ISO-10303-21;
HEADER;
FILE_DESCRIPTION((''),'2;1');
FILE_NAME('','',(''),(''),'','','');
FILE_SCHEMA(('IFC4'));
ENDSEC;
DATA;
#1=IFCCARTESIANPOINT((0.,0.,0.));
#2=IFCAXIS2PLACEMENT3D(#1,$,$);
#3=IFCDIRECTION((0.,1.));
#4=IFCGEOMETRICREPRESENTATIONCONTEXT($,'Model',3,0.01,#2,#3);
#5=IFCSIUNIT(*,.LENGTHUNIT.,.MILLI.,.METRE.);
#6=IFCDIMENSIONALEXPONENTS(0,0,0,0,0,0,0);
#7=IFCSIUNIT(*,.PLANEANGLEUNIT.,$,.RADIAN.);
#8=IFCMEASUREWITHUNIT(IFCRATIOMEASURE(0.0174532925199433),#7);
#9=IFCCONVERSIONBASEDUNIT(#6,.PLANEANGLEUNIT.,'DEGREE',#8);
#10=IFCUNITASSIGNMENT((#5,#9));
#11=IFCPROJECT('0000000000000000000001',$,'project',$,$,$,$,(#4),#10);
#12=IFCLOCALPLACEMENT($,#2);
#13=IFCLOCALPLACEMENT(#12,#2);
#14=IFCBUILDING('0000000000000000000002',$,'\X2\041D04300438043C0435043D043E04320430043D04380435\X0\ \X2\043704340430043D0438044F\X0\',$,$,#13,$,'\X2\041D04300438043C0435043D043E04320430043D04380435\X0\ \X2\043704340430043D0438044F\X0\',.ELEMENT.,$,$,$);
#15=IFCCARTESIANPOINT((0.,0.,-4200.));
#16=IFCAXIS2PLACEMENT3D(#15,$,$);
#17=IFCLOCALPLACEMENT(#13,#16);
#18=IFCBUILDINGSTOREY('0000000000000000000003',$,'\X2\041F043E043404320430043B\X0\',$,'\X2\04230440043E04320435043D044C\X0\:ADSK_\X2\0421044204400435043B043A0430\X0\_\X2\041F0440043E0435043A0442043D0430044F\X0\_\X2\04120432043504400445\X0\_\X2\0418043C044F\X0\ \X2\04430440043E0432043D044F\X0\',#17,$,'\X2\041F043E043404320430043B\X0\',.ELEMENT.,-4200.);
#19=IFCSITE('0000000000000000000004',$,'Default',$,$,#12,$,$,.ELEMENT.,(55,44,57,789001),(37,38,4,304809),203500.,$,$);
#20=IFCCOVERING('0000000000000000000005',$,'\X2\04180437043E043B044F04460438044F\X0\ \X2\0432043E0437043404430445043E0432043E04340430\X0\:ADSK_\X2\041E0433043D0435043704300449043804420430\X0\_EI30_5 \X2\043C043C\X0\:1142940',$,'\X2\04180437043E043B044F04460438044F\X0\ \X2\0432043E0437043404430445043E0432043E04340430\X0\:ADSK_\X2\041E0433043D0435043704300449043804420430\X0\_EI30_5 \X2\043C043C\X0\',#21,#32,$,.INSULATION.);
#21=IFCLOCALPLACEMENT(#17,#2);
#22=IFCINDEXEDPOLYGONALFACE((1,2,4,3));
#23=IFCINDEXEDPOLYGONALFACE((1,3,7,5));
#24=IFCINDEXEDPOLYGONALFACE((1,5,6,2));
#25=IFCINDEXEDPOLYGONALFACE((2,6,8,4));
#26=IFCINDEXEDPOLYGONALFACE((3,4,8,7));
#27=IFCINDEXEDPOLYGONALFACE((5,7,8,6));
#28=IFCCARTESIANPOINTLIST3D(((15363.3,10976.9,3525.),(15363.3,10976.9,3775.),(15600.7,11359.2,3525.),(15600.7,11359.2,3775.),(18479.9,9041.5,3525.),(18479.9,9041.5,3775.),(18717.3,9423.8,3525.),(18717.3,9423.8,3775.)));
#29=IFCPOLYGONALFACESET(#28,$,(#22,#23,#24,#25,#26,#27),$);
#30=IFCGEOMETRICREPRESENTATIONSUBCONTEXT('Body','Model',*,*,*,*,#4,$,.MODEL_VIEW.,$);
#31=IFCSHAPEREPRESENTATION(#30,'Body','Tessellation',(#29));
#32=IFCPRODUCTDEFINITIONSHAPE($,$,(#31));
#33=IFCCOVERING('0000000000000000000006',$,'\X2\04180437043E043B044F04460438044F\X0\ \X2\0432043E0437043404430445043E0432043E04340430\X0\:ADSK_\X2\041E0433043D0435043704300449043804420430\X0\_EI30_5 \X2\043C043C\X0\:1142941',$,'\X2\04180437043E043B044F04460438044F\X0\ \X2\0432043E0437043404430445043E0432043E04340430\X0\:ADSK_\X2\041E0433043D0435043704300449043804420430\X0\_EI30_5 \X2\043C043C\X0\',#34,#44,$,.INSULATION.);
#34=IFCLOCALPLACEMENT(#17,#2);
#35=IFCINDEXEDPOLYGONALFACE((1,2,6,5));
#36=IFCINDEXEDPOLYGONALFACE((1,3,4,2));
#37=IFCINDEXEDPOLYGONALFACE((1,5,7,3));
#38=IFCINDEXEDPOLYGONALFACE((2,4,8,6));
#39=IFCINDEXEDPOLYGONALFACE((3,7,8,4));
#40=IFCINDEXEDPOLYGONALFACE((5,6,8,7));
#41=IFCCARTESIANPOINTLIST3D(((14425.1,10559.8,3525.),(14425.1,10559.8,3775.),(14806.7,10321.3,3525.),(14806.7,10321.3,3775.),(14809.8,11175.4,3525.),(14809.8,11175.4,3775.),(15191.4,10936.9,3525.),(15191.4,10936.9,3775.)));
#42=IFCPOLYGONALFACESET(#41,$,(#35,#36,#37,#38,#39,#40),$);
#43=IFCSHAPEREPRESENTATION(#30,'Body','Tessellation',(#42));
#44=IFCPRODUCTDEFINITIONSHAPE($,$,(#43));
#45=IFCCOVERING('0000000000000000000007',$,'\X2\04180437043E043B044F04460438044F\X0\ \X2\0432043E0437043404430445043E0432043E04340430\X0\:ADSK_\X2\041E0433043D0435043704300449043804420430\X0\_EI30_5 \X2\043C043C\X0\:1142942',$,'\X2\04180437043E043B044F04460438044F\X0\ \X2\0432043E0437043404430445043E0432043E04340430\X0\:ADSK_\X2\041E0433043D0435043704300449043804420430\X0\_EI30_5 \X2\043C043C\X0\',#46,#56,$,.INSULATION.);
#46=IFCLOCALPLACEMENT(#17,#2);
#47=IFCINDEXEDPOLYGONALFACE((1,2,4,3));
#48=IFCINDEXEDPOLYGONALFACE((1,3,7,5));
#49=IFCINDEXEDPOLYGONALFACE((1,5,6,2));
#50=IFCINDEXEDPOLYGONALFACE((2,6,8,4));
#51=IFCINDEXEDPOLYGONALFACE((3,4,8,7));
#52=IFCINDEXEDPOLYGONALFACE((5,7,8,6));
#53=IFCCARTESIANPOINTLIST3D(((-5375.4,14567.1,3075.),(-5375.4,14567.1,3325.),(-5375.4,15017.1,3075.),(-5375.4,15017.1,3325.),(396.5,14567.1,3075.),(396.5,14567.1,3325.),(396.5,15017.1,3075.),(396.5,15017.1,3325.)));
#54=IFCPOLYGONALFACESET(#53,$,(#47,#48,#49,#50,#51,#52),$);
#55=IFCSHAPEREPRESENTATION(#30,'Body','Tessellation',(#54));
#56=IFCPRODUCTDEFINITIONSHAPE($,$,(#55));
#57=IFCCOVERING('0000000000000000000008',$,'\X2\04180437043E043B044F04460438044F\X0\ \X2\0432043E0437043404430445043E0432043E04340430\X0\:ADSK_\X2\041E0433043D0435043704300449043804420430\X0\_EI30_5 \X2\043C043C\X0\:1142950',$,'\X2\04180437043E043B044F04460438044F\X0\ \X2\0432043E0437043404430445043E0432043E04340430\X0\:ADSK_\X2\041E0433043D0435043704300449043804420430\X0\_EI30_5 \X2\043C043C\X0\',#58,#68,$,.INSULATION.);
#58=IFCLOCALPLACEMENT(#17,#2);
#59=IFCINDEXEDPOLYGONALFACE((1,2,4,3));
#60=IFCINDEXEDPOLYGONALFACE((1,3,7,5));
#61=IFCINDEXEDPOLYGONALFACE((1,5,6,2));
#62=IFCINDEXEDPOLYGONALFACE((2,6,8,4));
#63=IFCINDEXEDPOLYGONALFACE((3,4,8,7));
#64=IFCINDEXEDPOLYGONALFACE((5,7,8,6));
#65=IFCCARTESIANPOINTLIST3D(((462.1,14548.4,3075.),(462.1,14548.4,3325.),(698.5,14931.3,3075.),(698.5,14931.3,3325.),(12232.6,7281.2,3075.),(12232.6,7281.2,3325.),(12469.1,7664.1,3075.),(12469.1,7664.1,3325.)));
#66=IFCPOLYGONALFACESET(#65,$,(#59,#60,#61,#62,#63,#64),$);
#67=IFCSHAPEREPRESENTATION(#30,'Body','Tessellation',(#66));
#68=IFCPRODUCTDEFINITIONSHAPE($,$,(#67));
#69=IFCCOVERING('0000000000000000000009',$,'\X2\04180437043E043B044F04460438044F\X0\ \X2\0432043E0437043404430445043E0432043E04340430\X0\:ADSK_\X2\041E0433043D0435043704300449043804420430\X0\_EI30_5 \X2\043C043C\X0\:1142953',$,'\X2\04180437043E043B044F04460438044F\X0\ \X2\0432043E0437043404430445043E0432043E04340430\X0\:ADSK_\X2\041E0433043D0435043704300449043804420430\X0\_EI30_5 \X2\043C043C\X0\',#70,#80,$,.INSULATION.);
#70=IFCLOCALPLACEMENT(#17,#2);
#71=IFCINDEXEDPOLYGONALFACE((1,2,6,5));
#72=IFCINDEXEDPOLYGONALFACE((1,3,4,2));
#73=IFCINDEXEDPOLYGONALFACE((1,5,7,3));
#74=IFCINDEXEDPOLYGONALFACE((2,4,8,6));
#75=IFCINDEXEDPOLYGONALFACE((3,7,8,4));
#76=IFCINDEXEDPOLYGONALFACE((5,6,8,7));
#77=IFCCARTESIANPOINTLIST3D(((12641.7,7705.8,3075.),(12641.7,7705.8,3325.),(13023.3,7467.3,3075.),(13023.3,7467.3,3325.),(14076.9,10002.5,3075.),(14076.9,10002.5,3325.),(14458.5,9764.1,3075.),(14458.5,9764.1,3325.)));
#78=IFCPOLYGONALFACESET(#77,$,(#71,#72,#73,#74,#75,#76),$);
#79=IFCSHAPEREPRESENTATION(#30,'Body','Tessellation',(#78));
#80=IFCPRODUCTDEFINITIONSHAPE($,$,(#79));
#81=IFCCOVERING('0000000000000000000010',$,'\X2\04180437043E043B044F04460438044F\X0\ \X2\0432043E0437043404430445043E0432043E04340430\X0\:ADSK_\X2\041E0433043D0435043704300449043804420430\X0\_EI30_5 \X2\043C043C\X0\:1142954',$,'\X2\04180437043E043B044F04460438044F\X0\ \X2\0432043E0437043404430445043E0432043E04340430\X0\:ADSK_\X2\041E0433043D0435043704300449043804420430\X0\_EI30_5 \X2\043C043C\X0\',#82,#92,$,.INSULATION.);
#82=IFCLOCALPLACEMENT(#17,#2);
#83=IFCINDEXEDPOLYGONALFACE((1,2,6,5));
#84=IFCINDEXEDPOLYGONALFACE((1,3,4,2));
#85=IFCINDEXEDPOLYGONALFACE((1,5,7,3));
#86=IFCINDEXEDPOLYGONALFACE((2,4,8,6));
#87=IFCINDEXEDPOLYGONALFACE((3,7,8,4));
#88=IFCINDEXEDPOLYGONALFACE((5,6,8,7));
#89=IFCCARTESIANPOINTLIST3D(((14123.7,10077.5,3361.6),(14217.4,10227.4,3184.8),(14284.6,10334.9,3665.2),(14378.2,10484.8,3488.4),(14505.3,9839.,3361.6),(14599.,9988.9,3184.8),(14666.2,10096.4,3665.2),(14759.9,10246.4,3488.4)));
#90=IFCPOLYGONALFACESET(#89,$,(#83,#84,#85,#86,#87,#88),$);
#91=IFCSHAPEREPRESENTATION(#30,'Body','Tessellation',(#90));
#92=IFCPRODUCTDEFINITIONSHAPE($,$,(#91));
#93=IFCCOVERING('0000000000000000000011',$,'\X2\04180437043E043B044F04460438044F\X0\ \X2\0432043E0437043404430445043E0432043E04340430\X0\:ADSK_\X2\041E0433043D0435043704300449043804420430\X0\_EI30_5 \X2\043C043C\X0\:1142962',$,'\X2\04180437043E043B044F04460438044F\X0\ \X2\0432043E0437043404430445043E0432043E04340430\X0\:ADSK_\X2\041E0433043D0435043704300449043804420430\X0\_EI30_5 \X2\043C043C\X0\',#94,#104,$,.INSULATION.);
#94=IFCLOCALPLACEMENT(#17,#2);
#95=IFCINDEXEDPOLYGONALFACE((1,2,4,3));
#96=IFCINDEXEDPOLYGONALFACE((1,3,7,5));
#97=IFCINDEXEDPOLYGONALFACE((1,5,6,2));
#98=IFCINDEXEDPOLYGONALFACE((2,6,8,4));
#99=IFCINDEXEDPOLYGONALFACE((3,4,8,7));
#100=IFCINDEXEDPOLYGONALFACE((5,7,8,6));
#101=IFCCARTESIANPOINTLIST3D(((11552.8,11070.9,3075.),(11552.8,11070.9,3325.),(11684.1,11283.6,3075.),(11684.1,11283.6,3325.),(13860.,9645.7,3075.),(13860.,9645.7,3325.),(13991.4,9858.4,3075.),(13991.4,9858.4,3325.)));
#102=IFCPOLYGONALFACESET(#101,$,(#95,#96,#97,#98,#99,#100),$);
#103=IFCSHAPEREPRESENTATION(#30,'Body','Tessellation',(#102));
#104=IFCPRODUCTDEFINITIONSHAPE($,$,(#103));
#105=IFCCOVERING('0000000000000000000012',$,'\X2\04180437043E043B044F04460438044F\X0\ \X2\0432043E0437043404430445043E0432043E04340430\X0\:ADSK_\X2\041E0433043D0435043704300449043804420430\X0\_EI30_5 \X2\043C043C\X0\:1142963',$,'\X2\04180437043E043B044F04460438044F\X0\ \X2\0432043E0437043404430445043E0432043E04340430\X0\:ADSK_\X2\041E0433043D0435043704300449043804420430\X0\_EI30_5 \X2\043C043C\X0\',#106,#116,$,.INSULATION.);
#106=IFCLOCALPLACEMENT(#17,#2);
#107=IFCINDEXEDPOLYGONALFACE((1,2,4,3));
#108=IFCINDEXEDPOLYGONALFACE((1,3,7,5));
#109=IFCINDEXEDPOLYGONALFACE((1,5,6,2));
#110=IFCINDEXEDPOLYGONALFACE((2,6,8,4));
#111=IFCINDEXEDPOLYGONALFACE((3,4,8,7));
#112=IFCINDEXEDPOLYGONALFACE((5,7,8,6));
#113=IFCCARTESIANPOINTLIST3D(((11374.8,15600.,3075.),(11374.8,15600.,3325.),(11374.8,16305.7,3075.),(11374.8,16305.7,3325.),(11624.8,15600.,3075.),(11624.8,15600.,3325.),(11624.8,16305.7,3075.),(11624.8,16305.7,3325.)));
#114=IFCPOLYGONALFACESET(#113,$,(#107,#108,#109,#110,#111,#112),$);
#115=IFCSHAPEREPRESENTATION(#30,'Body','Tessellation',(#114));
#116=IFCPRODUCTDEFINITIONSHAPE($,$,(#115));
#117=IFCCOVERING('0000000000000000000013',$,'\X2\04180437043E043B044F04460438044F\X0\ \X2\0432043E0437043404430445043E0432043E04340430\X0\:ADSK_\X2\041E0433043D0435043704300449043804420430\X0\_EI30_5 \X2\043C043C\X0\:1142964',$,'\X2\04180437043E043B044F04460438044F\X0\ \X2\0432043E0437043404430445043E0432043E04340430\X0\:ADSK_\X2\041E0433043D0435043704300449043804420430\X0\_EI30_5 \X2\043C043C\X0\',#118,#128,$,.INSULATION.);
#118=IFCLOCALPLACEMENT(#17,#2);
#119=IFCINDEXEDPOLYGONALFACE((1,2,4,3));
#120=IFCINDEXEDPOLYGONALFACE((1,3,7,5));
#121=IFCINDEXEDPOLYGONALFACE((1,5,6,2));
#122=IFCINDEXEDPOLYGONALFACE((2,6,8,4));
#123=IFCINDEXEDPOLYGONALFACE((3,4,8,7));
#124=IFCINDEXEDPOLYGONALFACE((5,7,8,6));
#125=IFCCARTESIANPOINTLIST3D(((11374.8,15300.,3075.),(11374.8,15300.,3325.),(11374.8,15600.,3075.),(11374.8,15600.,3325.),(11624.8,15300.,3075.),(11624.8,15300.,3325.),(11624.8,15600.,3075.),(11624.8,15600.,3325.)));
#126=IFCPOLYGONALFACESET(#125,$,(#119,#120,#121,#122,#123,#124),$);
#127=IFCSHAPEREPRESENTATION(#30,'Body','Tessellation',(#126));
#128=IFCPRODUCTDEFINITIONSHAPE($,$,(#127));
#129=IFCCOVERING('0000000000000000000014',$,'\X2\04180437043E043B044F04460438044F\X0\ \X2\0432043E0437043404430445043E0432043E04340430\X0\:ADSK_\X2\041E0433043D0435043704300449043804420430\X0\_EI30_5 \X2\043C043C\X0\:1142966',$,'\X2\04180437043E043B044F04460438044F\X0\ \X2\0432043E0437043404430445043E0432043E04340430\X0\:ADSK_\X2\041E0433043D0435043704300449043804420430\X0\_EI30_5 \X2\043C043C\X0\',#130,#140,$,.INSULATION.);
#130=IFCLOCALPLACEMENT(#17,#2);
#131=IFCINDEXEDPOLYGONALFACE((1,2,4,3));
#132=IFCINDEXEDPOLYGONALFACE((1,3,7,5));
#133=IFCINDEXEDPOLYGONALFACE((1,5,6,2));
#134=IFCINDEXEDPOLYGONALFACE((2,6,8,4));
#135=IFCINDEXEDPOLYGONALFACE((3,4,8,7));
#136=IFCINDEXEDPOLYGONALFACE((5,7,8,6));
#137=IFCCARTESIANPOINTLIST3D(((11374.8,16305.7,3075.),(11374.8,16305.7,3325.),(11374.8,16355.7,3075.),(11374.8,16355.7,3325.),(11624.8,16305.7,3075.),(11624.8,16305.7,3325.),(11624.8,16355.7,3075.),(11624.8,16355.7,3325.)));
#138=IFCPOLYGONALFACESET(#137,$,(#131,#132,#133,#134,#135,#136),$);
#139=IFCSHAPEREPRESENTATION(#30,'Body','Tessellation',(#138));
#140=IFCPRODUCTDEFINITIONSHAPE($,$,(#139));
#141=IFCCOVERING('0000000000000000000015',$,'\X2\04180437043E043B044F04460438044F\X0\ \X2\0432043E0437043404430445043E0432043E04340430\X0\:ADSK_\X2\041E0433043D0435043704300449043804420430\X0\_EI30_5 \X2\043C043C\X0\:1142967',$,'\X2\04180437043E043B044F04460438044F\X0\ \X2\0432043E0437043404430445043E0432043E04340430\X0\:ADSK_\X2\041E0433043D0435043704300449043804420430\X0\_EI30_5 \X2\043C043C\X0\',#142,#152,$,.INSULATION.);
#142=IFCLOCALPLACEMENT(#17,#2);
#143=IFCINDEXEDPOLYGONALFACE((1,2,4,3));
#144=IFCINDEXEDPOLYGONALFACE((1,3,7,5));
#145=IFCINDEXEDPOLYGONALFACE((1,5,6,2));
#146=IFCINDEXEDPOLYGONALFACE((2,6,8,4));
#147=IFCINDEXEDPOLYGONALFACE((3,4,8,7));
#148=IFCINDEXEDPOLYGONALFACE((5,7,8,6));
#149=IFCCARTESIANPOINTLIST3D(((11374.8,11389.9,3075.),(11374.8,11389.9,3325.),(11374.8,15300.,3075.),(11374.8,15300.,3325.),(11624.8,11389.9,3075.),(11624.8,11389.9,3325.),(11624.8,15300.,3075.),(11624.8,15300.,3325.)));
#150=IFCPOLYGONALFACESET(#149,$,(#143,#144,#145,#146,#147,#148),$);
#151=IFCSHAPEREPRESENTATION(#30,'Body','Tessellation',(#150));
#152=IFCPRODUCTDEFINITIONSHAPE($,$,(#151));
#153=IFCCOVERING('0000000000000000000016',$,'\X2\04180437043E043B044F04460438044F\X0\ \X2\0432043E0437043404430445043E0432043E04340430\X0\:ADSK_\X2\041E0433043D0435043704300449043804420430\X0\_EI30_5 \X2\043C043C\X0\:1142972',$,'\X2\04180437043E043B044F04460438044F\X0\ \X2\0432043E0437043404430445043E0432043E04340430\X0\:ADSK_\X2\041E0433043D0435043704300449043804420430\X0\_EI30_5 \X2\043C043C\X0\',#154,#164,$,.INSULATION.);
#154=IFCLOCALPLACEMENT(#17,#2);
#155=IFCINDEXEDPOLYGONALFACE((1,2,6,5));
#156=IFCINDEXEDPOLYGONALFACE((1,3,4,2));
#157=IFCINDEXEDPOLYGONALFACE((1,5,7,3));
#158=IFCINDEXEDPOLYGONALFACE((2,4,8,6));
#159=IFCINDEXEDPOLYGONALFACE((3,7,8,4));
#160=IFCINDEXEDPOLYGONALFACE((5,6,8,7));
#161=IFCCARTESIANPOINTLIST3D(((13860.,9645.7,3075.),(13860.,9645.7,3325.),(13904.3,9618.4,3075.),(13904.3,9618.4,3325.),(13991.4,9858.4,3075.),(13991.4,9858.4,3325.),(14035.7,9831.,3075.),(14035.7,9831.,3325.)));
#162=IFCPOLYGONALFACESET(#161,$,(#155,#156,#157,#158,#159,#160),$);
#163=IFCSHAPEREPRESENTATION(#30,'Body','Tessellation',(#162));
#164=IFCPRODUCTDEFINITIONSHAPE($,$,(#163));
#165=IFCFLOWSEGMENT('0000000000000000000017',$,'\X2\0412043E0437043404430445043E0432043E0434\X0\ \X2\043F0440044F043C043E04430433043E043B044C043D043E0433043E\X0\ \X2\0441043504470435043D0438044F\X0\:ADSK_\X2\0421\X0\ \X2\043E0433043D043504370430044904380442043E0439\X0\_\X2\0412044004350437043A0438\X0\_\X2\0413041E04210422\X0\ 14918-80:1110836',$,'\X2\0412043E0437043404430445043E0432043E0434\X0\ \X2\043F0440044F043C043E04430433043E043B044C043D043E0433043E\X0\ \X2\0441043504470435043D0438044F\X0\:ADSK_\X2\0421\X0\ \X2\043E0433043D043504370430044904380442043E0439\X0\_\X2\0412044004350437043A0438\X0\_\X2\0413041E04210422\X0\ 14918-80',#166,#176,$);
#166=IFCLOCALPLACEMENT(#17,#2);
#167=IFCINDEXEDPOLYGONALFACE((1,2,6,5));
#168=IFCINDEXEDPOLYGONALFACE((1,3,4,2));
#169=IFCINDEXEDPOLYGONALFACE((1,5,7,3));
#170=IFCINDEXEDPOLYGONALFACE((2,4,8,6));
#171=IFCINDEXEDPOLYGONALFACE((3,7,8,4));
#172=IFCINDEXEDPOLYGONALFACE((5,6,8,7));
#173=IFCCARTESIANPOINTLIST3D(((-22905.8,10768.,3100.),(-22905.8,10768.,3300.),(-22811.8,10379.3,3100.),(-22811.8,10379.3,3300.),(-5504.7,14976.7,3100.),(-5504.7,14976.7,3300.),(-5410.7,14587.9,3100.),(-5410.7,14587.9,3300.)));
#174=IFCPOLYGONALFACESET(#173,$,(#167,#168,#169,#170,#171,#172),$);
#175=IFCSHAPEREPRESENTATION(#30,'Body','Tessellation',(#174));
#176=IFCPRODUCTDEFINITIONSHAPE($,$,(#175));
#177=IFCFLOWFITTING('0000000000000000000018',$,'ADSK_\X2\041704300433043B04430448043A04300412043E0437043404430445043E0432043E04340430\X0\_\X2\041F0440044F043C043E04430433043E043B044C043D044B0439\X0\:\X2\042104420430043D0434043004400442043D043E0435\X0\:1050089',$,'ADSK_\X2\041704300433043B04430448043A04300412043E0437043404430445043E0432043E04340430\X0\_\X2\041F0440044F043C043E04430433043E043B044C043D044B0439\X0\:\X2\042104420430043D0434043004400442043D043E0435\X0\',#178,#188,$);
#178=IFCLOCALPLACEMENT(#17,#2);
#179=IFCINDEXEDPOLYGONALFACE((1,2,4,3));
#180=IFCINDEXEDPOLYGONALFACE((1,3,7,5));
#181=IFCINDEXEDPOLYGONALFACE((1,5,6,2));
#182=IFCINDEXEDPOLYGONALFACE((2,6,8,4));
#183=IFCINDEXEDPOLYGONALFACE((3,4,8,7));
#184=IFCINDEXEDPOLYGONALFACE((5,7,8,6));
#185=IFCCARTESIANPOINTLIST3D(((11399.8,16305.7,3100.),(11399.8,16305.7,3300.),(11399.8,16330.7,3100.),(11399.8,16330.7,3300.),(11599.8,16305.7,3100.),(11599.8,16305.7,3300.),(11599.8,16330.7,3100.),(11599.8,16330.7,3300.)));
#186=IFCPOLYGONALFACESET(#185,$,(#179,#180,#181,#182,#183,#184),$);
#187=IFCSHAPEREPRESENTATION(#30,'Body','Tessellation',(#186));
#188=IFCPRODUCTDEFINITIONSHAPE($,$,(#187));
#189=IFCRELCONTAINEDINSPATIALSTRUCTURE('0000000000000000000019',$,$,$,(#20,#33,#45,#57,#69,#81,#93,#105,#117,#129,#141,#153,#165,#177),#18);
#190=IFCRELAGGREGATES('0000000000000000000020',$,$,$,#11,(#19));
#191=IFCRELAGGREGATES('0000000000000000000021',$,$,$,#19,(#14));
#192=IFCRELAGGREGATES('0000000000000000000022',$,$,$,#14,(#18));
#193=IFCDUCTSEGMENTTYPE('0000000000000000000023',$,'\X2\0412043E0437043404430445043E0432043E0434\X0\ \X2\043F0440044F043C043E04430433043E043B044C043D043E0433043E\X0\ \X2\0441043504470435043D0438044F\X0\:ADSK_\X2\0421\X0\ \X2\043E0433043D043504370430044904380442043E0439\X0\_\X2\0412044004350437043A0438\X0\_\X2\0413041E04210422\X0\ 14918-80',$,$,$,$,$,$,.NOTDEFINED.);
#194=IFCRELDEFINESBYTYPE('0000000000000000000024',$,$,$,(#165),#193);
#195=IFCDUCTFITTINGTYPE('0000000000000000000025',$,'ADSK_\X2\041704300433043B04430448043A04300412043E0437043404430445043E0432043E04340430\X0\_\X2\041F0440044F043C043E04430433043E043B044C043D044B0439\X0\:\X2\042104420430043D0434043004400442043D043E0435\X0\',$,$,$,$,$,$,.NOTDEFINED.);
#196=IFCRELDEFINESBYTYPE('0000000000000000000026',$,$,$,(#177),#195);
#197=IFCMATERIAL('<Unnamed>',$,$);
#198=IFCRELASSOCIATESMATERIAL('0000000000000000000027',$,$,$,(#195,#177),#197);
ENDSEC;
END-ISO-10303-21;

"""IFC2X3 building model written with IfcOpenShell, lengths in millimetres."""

from ifc_helpers import new_model, entity, si_unit, converted_unit, direction, frame, frame_2d, origin, origin_2d_with_axis, place, context, subcontext, project, spatial, rectangle, extrude, source, transform, mapped, material, type_object, type_shapes, element, save


model = new_model("IFC2X3")

# Units and contexts
model_context = context("Model", 3, precision=0.01, world=origin(), true_north=direction((0.0, 1.0)))
body_context = subcontext(model_context, "Body", "Model", "MODEL_VIEW")
ifc_project = project(units=[si_unit("LENGTHUNIT", "METRE", prefix="MILLI"), converted_unit("PLANEANGLEUNIT", "DEGREE", entity("IfcRatioMeasure", 0.0174532925199433), si_unit("PLANEANGLEUNIT", "RADIAN"), dimensions=[0, 0, 0, 0, 0, 0, 0])], contexts=[model_context])

# Site, building, storey
site_placement = place(None, frame((0.0, 0.0, 0.0)))
site = spatial("IfcSite", under=ifc_project, at=site_placement, Name="Default", CompositionType="ELEMENT", RefLatitude=(55, 44, 57, 789001), RefLongitude=(37, 38, 4, 304809), RefElevation=203500.0)
building_placement = place(site_placement, origin())
building = spatial("IfcBuilding", under=site, at=building_placement, Name="Наименование здания", LongName="Наименование здания", CompositionType="ELEMENT")
storey_placement = place(building_placement, frame((0.0, 0.0, -4200.0)))
storey = spatial("IfcBuildingStorey", under=building, at=storey_placement, Name="Подвал", ObjectType="Уровень:ADSK_Стрелка_Проектная_Вверх_Имя уровня", LongName="Подвал", CompositionType="ELEMENT", Elevation=-4200.0)

# Coverings
covering_1_placement = place(storey_placement, frame((15363.3, 9041.5, 3525.0)))
element("IfcCovering", 1, at=covering_1_placement, inside=storey, Name="Изоляция воздуховода:ADSK_Огнезащита_EI30_5 мм:1142940", ObjectType="Изоляция воздуховода:ADSK_Огнезащита_EI30_5 мм", PredefinedType="INSULATION", context=body_context, shape_type="SweptSolid", body=[
    extrude(rectangle(XDim=3668.6, YDim=450.0, at=frame_2d((0.0, 0.0), x_axis=(1.0, 0.0))), frame((1677.0, 1158.8, 0.0), z_axis=(0.0, 0.0, 1.0), x_axis=(-0.849526, 0.527546, 0.0)), (0.0, 0.0, 1.0), 250.0),
])
covering_2_placement = place(storey_placement, frame((14425.1, 10321.3, 3525.0)))
element("IfcCovering", 2, at=covering_2_placement, inside=storey, Name="Изоляция воздуховода:ADSK_Огнезащита_EI30_5 мм:1142941", ObjectType="Изоляция воздуховода:ADSK_Огнезащита_EI30_5 мм", PredefinedType="INSULATION", context=body_context, shape_type="SweptSolid", body=[
    extrude(rectangle(XDim=725.9, YDim=450.0, at=origin_2d_with_axis()), frame((383.2, 427.0, 0.0), z_axis=(0.0, 0.0, 1.0), x_axis=(-0.529919, -0.848048, 0.0)), (0.0, 0.0, 1.0), 250.0),
])
covering_3_placement = place(storey_placement, frame((-5375.4, 14567.1, 3075.0)))
element("IfcCovering", 3, at=covering_3_placement, inside=storey, Name="Изоляция воздуховода:ADSK_Огнезащита_EI30_5 мм:1142942", ObjectType="Изоляция воздуховода:ADSK_Огнезащита_EI30_5 мм", PredefinedType="INSULATION", context=body_context, shape_type="SweptSolid", body=[
    extrude(rectangle(XDim=5771.9, YDim=450.0, at=frame_2d((0.0, 0.0), x_axis=(1.0, 0.0))), frame((2886.0, 225.0, 0.0)), (0.0, 0.0, 1.0), 250.0),
])
covering_4_placement = place(storey_placement, frame((462.1, 7281.2, 3075.0)))
element("IfcCovering", 4, at=covering_4_placement, inside=storey, Name="Изоляция воздуховода:ADSK_Огнезащита_EI30_5 мм:1142950", ObjectType="Изоляция воздуховода:ADSK_Огнезащита_EI30_5 мм", PredefinedType="INSULATION", context=body_context, shape_type="SweptSolid", body=[
    extrude(rectangle(XDim=13833.2, YDim=450.0, at=frame_2d((0.0, 0.0), x_axis=(1.0, 0.0))), frame((6003.5, 3825.1, 0.0), z_axis=(0.0, 0.0, 1.0), x_axis=(0.850888, -0.525347, 0.0)), (0.0, 0.0, 1.0), 250.0),
])
covering_5_placement = place(storey_placement, frame((12641.7, 7467.3, 3075.0)))
element("IfcCovering", 5, at=covering_5_placement, inside=storey, Name="Изоляция воздуховода:ADSK_Огнезащита_EI30_5 мм:1142953", ObjectType="Изоляция воздуховода:ADSK_Огнезащита_EI30_5 мм", PredefinedType="INSULATION", context=body_context, shape_type="SweptSolid", body=[
    extrude(rectangle(XDim=2708.2, YDim=450.0, at=frame_2d((0.0, 0.0), x_axis=(1.0, 0.0))), frame((908.4, 1267.6, 0.0), z_axis=(0.0, 0.0, 1.0), x_axis=(0.529919, 0.848048, 0.0)), (0.0, 0.0, 1.0), 250.0),
])
covering_6_placement = place(storey_placement, frame((14123.7, 9839.0, 3184.8)))
element("IfcCovering", 6, at=covering_6_placement, inside=storey, Name="Изоляция воздуховода:ADSK_Огнезащита_EI30_5 мм:1142954", ObjectType="Изоляция воздуховода:ADSK_Огнезащита_EI30_5 мм", PredefinedType="INSULATION", context=body_context, shape_type="SweptSolid", body=[
    extrude(rectangle(XDim=429.3, YDim=250.0, at=frame_2d((0.0, 0.0), x_axis=(1.0, 0.0))), frame((127.3, 442.1, 240.2), z_axis=(0.848048, -0.529919, 0.0), x_axis=(0.37471, 0.599661, 0.707107)), (0.0, 0.0, 1.0), 450.0),
])
covering_7_placement = place(storey_placement, frame((11552.8, 9645.7, 3075.0)))
element("IfcCovering", 7, at=covering_7_placement, inside=storey, Name="Изоляция воздуховода:ADSK_Огнезащита_EI30_5 мм:1142962", ObjectType="Изоляция воздуховода:ADSK_Огнезащита_EI30_5 мм", PredefinedType="INSULATION", context=body_context, shape_type="SweptSolid", body=[
    extrude(rectangle(XDim=2711.9, YDim=250.0, at=frame_2d((0.0, 0.0), x_axis=(1.0, 0.0))), frame((1219.3, 818.9, 0.0), z_axis=(0.0, 0.0, 1.0), x_axis=(0.850783, -0.525517, 0.0)), (0.0, 0.0, 1.0), 250.0),
])
covering_8_placement = place(storey_placement, frame((11374.8, 15600.0, 3075.0)))
element("IfcCovering", 8, at=covering_8_placement, inside=storey, Name="Изоляция воздуховода:ADSK_Огнезащита_EI30_5 мм:1142963", ObjectType="Изоляция воздуховода:ADSK_Огнезащита_EI30_5 мм", PredefinedType="INSULATION", context=body_context, shape_type="SweptSolid", body=[
    extrude(rectangle(XDim=705.7, YDim=250.0, at=origin_2d_with_axis()), frame((125.0, 352.8, 0.0), z_axis=(0.0, 0.0, 1.0), x_axis=(0.0, 1.0, 0.0)), (0.0, 0.0, 1.0), 250.0),
])
covering_9_placement = place(storey_placement, frame((11374.8, 15300.0, 3075.0)))
element("IfcCovering", 9, at=covering_9_placement, inside=storey, Name="Изоляция воздуховода:ADSK_Огнезащита_EI30_5 мм:1142964", ObjectType="Изоляция воздуховода:ADSK_Огнезащита_EI30_5 мм", PredefinedType="INSULATION", context=body_context, shape_type="SweptSolid", body=[
    extrude(rectangle(XDim=300.0, YDim=250.0, at=frame_2d((0.0, 0.0), x_axis=(1.0, 0.0))), frame((125.0, 150.0, 0.0), z_axis=(0.0, 0.0, 1.0), x_axis=(0.0, 1.0, 0.0)), (0.0, 0.0, 1.0), 250.0),
])
covering_10_placement = place(storey_placement, frame((11374.8, 16305.7, 3075.0)))
element("IfcCovering", 10, at=covering_10_placement, inside=storey, Name="Изоляция воздуховода:ADSK_Огнезащита_EI30_5 мм:1142966", ObjectType="Изоляция воздуховода:ADSK_Огнезащита_EI30_5 мм", PredefinedType="INSULATION", context=body_context, shape_type="SweptSolid", body=[
    extrude(rectangle(XDim=50.0, YDim=250.0, at=frame_2d((0.0, 0.0), x_axis=(1.0, 0.0))), frame((125.0, 25.0, 0.0), z_axis=(0.0, 0.0, 1.0), x_axis=(0.0, -1.0, 0.0)), (0.0, 0.0, 1.0), 250.0),
])
covering_11_placement = place(storey_placement, frame((11374.8, 11389.9, 3075.0)))
element("IfcCovering", 11, at=covering_11_placement, inside=storey, Name="Изоляция воздуховода:ADSK_Огнезащита_EI30_5 мм:1142967", ObjectType="Изоляция воздуховода:ADSK_Огнезащита_EI30_5 мм", PredefinedType="INSULATION", context=body_context, shape_type="SweptSolid", body=[
    extrude(rectangle(XDim=3910.1, YDim=250.0, at=frame_2d((0.0, 0.0), x_axis=(1.0, 0.0))), frame((125.0, 1955.0, 0.0), z_axis=(0.0, 0.0, 1.0), x_axis=(0.0, 1.0, 0.0)), (0.0, 0.0, 1.0), 250.0),
])
covering_12_placement = place(storey_placement, frame((13860.0, 9618.4, 3075.0)))
element("IfcCovering", 12, at=covering_12_placement, inside=storey, Name="Изоляция воздуховода:ADSK_Огнезащита_EI30_5 мм:1142972", ObjectType="Изоляция воздуховода:ADSK_Огнезащита_EI30_5 мм", PredefinedType="INSULATION", context=body_context, shape_type="SweptSolid", body=[
    extrude(rectangle(XDim=52.1, YDim=250.0, at=origin_2d_with_axis()), frame((87.9, 120.0, 0.0), z_axis=(0.0, 0.0, 1.0), x_axis=(0.850783, -0.525517, 0.0)), (0.0, 0.0, 1.0), 250.0),
])

# Flow segment
duct_segment_type = type_object("IfcDuctSegmentType", Name="Воздуховод прямоугольного сечения:ADSK_С огнезащитой_Врезки_ГОСТ 14918-80", PredefinedType="NOTDEFINED")
flow_segment_placement = place(storey_placement, frame((-22905.8, 10379.3, 3100.0)))
element("IfcFlowSegment", 13, at=flow_segment_placement, inside=storey, type_object=duct_segment_type, Name="Воздуховод прямоугольного сечения:ADSK_С огнезащитой_Врезки_ГОСТ 14918-80:1110836", ObjectType="Воздуховод прямоугольного сечения:ADSK_С огнезащитой_Врезки_ГОСТ 14918-80", context=body_context, shape_type="SweptSolid", body=[
    extrude(rectangle(XDim=17902.8, YDim=400.0, at=origin_2d_with_axis()), frame((8747.6, 2298.7, 0.0), z_axis=(0.0, 0.0, 1.0), x_axis=(-0.971976, -0.235081, 0.0)), (0.0, 0.0, 1.0), 200.0),
])

# Flow fitting
ifc_material_1 = material(Name="<Unnamed>")
duct_fitting_type_1 = type_object("IfcDuctFittingType", Name="ADSK_ЗаглушкаВоздуховода_Прямоугольный:Стандартное", PredefinedType="NOTDEFINED", material=ifc_material_1)
shared_shape_1 = source(origin(), body_context, "Body", "SweptSolid", [
    extrude(rectangle(XDim=25.0, YDim=200.0, at=frame_2d((0.0, 0.0), x_axis=(1.0, 0.0))), frame((12.5, 0.0, -100.0)), (0.0, 0.0, 1.0), 200.0),
])
type_shapes(duct_fitting_type_1, [shared_shape_1])
flow_fitting_1_placement = place(storey_placement, frame((11499.8, 16305.7, 3200.0), z_axis=(0.0, 0.0, 1.0), x_axis=(0.0, 1.0, 0.0)))
element("IfcFlowFitting", 14, at=flow_fitting_1_placement, inside=storey, type_object=duct_fitting_type_1, material=ifc_material_1, Name="ADSK_ЗаглушкаВоздуховода_Прямоугольный:Стандартное:1050089", ObjectType="ADSK_ЗаглушкаВоздуховода_Прямоугольный:Стандартное", context=body_context, shape_type="MappedRepresentation", body=[
    mapped(shared_shape_1, transform((0.0, 0.0, 0.0), scale=1.0)),
])

save(model, "model.ifc")
